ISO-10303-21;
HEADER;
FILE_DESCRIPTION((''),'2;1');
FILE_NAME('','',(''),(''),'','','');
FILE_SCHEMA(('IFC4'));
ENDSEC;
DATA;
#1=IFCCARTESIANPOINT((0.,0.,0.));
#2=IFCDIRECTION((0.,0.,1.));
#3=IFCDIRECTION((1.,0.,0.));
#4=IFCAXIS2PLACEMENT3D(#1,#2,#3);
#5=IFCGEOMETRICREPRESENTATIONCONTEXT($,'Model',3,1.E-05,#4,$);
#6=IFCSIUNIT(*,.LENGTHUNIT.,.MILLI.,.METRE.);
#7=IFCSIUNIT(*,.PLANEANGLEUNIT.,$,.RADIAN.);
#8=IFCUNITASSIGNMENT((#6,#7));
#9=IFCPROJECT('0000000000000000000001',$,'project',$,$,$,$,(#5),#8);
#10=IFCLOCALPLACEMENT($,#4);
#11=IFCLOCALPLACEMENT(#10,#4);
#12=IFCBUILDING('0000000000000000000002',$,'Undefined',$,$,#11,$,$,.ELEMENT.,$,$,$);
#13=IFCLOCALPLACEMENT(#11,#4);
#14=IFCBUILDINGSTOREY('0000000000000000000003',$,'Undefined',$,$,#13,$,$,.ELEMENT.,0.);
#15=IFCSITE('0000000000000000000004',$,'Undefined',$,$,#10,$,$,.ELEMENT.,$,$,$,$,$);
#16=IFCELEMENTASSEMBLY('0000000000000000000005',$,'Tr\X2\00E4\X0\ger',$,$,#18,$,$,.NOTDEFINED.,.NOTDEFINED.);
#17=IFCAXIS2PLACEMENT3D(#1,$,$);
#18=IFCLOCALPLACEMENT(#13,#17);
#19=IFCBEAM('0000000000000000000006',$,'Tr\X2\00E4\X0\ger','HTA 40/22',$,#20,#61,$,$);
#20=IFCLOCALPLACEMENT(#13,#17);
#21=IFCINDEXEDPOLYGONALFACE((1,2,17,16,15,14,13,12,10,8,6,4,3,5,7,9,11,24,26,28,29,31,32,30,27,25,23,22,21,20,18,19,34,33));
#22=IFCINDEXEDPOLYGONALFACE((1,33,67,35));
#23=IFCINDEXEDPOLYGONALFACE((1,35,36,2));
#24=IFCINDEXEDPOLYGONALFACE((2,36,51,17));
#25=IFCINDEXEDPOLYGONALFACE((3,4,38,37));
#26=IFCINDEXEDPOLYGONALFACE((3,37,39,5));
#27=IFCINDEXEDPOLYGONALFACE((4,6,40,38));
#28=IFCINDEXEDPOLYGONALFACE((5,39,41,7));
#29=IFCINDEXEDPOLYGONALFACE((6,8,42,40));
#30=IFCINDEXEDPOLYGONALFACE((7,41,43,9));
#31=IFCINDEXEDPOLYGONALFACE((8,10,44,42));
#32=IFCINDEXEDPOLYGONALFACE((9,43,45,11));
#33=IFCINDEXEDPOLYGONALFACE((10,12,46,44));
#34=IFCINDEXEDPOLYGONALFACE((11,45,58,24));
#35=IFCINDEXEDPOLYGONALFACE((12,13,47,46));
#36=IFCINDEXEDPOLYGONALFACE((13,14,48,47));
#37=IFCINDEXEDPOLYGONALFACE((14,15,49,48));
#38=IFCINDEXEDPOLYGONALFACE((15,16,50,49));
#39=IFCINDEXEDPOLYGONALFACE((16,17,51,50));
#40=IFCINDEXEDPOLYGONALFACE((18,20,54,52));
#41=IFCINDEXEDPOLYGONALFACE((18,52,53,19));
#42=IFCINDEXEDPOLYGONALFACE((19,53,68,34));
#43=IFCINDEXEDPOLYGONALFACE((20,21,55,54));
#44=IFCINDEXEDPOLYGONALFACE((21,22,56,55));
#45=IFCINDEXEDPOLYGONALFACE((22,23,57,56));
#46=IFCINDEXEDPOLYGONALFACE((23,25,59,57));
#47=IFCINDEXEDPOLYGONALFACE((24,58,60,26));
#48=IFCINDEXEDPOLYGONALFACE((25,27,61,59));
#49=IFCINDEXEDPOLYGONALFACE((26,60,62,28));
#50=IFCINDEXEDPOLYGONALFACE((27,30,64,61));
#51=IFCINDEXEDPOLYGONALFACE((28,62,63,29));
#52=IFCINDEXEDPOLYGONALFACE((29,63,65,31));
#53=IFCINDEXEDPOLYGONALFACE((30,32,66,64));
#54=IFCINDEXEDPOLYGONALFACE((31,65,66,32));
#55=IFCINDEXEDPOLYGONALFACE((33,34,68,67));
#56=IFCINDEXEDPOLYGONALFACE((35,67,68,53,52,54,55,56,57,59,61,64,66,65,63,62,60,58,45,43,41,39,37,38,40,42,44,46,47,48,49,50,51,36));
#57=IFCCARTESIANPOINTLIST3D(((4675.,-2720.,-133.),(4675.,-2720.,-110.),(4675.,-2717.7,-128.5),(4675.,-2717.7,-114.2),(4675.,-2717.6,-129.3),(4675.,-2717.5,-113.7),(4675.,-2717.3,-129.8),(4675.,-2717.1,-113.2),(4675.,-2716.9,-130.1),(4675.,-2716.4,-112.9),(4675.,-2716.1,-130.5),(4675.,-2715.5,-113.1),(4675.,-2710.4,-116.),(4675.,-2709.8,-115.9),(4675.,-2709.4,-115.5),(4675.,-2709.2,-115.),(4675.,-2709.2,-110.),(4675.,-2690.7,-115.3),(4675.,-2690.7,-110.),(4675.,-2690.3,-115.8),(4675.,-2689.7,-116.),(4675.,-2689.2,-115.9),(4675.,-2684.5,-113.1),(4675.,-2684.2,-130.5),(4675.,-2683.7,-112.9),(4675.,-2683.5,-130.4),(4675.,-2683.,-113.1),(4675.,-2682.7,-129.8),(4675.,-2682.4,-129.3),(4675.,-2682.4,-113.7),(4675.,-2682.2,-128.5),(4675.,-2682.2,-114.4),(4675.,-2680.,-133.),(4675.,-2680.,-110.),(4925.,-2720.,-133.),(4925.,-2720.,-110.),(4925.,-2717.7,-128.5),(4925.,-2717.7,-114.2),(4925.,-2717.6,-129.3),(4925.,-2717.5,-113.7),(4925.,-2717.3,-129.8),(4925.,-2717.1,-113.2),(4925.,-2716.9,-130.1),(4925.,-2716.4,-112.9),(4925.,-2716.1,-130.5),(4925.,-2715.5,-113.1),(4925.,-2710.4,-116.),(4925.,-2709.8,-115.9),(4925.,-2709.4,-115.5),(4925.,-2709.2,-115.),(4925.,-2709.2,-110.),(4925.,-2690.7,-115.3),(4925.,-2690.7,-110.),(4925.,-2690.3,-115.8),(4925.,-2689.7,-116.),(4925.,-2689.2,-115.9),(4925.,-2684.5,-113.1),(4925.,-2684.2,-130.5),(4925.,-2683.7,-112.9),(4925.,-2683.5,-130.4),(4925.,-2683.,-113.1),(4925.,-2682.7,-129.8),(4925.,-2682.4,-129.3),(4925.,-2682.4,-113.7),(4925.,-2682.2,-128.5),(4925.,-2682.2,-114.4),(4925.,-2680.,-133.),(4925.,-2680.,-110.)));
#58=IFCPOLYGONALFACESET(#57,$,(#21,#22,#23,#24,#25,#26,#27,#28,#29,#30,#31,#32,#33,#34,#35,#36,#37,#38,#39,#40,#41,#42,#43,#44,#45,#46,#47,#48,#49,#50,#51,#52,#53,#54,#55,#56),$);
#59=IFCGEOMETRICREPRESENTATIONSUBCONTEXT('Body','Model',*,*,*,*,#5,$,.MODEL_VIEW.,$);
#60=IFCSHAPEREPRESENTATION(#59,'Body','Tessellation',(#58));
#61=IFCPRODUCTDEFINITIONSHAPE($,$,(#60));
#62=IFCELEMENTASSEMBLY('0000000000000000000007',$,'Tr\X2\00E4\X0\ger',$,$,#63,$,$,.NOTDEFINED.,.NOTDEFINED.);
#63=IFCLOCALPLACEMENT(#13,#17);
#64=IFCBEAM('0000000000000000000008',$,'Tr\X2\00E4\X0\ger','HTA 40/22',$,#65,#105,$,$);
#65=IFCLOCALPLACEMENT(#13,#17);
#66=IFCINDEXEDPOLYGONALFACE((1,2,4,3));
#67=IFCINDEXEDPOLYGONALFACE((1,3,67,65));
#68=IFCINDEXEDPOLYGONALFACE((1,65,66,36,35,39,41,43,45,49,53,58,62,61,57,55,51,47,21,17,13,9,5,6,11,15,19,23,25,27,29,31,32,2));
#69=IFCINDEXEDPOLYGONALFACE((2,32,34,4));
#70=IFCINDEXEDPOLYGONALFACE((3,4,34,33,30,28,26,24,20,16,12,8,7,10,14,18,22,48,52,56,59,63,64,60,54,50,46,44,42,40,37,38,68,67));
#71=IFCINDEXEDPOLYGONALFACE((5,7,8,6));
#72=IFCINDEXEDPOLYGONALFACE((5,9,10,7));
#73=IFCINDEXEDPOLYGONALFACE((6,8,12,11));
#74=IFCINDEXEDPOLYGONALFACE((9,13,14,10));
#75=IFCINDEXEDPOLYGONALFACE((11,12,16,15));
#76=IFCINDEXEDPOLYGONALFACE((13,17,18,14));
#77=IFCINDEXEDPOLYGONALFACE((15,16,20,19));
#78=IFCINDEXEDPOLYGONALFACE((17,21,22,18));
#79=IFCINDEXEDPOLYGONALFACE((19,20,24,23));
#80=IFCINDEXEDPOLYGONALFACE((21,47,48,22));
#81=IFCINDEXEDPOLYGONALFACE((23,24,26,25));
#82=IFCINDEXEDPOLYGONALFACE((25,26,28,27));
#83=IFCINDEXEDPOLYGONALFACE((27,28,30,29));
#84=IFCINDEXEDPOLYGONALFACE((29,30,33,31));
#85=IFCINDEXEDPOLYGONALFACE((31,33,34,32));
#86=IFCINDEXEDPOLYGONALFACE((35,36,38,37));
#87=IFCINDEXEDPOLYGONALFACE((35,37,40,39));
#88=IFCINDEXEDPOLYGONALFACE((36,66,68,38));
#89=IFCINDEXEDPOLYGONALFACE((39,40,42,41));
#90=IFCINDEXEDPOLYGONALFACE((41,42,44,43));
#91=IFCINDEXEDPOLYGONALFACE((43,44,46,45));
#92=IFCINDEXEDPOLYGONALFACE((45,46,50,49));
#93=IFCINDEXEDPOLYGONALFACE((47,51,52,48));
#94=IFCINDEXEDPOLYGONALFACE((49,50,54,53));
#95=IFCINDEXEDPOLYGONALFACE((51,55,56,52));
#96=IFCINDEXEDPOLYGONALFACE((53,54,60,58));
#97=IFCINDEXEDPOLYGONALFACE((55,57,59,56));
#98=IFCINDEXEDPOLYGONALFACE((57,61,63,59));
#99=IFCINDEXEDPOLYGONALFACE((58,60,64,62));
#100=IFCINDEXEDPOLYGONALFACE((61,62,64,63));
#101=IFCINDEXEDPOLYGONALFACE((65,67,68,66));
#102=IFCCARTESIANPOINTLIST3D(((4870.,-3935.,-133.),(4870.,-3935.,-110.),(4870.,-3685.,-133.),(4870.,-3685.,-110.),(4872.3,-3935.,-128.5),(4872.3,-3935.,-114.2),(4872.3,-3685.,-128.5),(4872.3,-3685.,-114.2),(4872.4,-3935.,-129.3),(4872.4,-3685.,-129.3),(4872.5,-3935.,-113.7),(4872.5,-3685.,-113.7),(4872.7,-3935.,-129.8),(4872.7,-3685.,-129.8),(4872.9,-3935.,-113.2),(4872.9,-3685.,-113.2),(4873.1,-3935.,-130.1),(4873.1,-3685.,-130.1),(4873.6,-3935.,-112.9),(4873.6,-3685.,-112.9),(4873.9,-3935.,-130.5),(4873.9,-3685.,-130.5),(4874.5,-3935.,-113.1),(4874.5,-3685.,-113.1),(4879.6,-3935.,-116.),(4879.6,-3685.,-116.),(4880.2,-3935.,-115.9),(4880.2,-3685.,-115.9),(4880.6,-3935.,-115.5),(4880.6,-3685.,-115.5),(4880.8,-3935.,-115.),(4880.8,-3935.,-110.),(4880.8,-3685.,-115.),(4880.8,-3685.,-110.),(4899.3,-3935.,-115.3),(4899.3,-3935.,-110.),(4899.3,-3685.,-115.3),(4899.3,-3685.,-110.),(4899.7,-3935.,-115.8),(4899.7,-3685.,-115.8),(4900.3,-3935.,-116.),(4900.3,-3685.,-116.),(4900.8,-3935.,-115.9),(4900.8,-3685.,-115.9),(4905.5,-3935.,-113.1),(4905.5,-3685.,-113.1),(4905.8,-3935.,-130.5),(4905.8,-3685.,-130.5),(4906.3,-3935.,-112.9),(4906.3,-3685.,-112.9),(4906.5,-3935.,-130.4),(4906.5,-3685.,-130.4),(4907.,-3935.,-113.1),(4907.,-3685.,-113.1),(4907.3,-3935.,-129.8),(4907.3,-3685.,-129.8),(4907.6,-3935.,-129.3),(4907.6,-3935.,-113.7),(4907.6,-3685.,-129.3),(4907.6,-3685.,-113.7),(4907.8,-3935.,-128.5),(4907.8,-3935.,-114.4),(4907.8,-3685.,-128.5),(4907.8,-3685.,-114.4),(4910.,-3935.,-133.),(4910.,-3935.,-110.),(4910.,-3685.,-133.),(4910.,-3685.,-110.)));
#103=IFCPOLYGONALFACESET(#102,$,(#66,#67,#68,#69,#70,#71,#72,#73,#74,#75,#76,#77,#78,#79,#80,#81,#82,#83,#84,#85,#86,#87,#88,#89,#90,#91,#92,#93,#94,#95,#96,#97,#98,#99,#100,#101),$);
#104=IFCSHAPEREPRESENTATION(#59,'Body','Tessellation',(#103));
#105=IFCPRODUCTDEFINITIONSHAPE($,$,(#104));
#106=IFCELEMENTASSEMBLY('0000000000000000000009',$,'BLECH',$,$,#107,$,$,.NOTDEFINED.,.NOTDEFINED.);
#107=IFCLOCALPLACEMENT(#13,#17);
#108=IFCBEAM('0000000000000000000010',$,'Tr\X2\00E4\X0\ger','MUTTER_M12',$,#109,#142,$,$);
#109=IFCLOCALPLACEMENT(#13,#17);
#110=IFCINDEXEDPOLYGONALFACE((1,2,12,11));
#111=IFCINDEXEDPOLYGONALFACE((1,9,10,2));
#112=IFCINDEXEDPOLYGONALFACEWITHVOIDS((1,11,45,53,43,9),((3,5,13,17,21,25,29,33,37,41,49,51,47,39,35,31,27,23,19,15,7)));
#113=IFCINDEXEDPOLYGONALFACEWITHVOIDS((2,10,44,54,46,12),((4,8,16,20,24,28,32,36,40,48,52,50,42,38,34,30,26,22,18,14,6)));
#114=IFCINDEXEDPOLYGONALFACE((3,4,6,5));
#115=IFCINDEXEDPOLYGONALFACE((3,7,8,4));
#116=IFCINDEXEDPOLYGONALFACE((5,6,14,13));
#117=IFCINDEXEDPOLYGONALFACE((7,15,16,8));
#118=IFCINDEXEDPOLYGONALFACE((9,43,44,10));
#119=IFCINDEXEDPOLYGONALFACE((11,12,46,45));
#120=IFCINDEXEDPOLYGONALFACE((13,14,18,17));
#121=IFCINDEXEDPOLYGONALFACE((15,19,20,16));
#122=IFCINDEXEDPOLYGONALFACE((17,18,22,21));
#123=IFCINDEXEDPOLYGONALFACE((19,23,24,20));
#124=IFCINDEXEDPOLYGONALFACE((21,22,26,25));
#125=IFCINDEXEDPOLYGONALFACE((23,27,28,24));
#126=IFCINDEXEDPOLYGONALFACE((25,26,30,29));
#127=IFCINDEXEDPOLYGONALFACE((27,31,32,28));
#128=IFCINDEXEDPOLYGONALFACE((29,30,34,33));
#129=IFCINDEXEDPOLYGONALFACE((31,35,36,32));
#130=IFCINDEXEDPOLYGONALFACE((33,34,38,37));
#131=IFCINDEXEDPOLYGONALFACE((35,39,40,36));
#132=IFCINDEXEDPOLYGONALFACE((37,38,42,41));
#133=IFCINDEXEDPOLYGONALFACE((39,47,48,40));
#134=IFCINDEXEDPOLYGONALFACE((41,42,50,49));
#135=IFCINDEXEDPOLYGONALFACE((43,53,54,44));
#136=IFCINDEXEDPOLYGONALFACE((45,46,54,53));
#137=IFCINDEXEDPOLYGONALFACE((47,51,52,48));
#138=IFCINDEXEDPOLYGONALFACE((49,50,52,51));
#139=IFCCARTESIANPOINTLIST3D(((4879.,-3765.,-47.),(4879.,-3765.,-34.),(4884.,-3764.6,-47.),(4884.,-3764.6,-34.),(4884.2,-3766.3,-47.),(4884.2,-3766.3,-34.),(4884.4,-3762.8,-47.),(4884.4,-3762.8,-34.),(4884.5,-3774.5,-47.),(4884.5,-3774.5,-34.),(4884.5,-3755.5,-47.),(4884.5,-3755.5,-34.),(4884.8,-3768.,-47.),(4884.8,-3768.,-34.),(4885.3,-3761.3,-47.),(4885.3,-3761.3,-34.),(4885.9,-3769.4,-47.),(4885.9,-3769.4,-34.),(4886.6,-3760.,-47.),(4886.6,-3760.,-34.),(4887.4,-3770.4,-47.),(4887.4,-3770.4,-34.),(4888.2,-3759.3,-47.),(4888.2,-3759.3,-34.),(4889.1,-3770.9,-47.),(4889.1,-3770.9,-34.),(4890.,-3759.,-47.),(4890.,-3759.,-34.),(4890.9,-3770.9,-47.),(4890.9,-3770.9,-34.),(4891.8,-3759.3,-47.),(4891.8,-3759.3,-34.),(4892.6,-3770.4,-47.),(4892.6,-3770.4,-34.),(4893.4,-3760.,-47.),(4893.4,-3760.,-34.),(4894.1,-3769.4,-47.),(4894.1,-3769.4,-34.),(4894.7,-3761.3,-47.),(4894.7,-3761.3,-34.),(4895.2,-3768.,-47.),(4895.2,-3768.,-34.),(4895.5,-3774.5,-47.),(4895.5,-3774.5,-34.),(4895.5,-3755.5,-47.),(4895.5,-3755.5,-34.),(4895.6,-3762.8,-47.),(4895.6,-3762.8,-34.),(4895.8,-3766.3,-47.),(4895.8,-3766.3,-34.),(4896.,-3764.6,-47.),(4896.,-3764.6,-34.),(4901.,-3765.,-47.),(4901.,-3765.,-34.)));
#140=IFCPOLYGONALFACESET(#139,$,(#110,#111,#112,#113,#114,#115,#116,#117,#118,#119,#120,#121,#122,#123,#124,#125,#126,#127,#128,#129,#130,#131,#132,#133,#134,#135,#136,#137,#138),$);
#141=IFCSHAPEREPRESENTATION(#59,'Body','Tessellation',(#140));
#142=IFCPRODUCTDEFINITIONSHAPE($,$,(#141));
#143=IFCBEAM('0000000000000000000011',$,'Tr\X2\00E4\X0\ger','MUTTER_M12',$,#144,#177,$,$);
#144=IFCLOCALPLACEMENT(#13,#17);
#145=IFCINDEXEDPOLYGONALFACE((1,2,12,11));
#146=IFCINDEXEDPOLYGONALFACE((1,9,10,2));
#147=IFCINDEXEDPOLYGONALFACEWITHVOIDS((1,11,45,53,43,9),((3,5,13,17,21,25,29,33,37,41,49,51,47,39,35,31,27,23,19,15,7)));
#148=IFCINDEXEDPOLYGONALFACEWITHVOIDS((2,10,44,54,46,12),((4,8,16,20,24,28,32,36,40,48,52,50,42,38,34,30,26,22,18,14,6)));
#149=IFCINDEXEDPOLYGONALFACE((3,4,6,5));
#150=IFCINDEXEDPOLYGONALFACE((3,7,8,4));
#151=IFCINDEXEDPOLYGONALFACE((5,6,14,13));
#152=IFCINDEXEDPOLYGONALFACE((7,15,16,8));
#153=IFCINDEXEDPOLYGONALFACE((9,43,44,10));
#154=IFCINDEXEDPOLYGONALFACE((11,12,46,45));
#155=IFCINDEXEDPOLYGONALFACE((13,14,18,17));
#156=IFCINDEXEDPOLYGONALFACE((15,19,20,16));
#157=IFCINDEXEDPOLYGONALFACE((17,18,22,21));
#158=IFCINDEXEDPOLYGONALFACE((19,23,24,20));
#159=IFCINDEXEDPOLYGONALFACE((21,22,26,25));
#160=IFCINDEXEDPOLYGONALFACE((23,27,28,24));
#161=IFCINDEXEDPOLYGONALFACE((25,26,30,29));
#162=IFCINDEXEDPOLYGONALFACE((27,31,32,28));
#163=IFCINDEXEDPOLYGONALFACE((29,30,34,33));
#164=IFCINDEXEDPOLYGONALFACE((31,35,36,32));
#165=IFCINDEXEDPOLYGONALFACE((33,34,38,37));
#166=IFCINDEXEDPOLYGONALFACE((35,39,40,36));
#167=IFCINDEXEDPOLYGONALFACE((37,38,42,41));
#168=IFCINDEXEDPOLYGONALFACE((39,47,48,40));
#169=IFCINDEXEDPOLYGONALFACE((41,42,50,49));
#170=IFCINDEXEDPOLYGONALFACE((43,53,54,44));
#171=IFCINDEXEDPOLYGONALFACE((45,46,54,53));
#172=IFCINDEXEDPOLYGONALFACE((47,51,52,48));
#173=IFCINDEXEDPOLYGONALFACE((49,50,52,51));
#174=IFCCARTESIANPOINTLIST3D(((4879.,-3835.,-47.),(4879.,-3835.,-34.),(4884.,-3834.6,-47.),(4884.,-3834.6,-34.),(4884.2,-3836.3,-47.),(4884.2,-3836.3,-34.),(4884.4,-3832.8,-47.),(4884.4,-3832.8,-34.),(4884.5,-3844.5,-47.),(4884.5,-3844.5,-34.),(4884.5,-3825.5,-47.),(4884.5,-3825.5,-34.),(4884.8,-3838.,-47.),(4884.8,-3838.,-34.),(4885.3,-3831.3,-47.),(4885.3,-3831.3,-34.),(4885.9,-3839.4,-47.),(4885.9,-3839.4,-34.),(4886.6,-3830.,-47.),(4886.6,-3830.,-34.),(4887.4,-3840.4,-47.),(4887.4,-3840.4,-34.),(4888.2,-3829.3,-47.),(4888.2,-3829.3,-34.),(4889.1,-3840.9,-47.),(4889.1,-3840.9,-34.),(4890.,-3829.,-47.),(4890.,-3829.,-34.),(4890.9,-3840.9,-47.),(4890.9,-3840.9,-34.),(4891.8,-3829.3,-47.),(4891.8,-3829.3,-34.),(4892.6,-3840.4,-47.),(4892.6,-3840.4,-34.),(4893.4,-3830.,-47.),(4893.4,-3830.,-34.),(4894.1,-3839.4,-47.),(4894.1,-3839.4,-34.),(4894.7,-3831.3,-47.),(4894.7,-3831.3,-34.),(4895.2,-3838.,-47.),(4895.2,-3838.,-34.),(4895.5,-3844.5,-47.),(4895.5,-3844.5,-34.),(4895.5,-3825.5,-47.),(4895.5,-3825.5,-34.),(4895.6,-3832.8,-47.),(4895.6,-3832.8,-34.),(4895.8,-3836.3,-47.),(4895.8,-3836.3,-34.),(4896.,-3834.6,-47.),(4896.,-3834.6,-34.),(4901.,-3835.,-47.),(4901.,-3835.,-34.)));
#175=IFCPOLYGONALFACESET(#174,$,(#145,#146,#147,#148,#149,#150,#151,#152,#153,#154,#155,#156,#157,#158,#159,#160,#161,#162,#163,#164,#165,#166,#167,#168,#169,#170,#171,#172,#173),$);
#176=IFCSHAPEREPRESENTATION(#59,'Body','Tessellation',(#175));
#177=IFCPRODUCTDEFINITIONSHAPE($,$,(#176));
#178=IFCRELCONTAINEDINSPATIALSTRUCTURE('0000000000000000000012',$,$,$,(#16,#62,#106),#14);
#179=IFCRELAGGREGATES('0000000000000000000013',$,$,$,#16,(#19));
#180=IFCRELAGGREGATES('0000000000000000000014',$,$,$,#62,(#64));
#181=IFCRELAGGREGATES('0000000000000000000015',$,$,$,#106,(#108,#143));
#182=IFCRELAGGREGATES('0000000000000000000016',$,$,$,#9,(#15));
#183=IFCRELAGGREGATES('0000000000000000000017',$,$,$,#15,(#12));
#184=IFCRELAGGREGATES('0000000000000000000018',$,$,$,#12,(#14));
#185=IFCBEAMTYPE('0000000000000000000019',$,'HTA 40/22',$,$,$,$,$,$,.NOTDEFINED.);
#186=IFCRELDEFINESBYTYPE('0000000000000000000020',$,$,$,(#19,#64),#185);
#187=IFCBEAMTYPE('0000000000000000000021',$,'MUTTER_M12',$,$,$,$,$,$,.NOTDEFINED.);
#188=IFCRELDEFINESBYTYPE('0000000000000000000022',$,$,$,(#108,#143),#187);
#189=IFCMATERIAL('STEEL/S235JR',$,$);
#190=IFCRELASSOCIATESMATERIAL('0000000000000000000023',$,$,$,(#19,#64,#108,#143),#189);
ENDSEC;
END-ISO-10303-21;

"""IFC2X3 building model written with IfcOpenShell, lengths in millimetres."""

from ifc_helpers import new_model, si_unit, frame, origin_with_axes, origin_2d_with_axis, place, context, subcontext, project, spatial, polyline, circle, outline, extrude, boolean, material, type_object, element, aggregate, save


model = new_model("IFC2X3")

# Units and contexts
model_context = context("Model", 3, precision=1e-05, world=origin_with_axes())
body_context = subcontext(model_context, "Body", "Model", "MODEL_VIEW")
ifc_project = project(units=[si_unit("LENGTHUNIT", "METRE", prefix="MILLI"), si_unit("PLANEANGLEUNIT", "RADIAN")], contexts=[model_context])

# Site, building, storey
site_placement = place(None, origin_with_axes())
site = spatial("IfcSite", under=ifc_project, at=site_placement, Name="Undefined", CompositionType="ELEMENT")
building_placement = place(site_placement, origin_with_axes())
building = spatial("IfcBuilding", under=site, at=building_placement, Name="Undefined", CompositionType="ELEMENT")
storey_placement = place(building_placement, origin_with_axes())
storey = spatial("IfcBuildingStorey", under=building, at=storey_placement, Name="Undefined", CompositionType="ELEMENT", Elevation=0.0)

# Element assemblies, beams
assembly_1_placement = place(storey_placement, origin_with_axes())
assembly_1 = element("IfcElementAssembly", 1, at=assembly_1_placement, inside=storey, Name="Träger", AssemblyPlace="NOTDEFINED", PredefinedType="NOTDEFINED")
ifc_material_1 = material(Name="STEEL/S235JR")
beam_type_1 = type_object("IfcBeamType", Name="HTA 40/22", PredefinedType="NOTDEFINED")
beam_1_placement = place(assembly_1_placement, frame((4925.0, -2700.0, -121.5), z_axis=(0.0, 0.0, -1.0), x_axis=(-1.0, 0.0, 0.0)))
beam_1 = element("IfcBeam", 2, at=beam_1_placement, type_object=beam_type_1, material=ifc_material_1, Name="Träger", Description="HTA 40/22", context=body_context, shape_type="SweptSolid", body=[
    extrude(outline(polyline([(-9.3, -6.2), (-9.2, -11.5), (-20.0, -11.5), (-20.0, 11.5), (20.0, 11.5), (20.0, -11.5), (9.2, -11.5), (9.2, -6.5), (9.4, -6.0), (9.8, -5.6), (10.4, -5.5), (15.5, -8.4), (16.4, -8.6), (17.1, -8.3), (17.5, -7.8), (17.7, -7.3), (17.8, 7.0), (17.6, 7.8), (17.3, 8.3), (16.9, 8.6), (16.1, 9.0), (-15.8, 9.0), (-16.5, 8.9), (-17.3, 8.3), (-17.6, 7.8), (-17.8, 7.0), (-17.8, -7.1), (-17.5, -7.8), (-17.0, -8.4), (-16.2, -8.6), (-15.5, -8.4), (-10.8, -5.6), (-10.2, -5.5), (-9.7, -5.7), (-9.3, -6.2)])), frame((250.0, 0.0, 0.0), z_axis=(-1.0, 0.0, 0.0), x_axis=(0.0, -1.0, 0.0)), (0.0, 0.0, 1.0), 250.0),
])
aggregate(assembly_1, [beam_1])
assembly_2_placement = place(storey_placement, origin_with_axes())
assembly_2 = element("IfcElementAssembly", 3, at=assembly_2_placement, inside=storey, Name="Träger", AssemblyPlace="NOTDEFINED", PredefinedType="NOTDEFINED")
beam_2_placement = place(assembly_2_placement, frame((4890.0, -3935.0, -121.5), z_axis=(0.0, 0.0, -1.0), x_axis=(0.0, 1.0, 0.0)))
beam_2 = element("IfcBeam", 4, at=beam_2_placement, type_object=beam_type_1, material=ifc_material_1, Name="Träger", Description="HTA 40/22", context=body_context, shape_type="SweptSolid", body=[
    extrude(outline(polyline([(-9.3, -6.2), (-9.2, -11.5), (-20.0, -11.5), (-20.0, 11.5), (20.0, 11.5), (20.0, -11.5), (9.2, -11.5), (9.2, -6.5), (9.4, -6.0), (9.8, -5.6), (10.4, -5.5), (15.5, -8.4), (16.4, -8.6), (17.1, -8.3), (17.5, -7.8), (17.7, -7.3), (17.8, 7.0), (17.6, 7.8), (17.3, 8.3), (16.9, 8.6), (16.1, 9.0), (-15.8, 9.0), (-16.5, 8.9), (-17.3, 8.3), (-17.6, 7.8), (-17.8, 7.0), (-17.8, -7.1), (-17.5, -7.8), (-17.0, -8.4), (-16.2, -8.6), (-15.5, -8.4), (-10.8, -5.6), (-10.2, -5.5), (-9.7, -5.7), (-9.3, -6.2)])), frame((250.0, 0.0, 0.0), z_axis=(-1.0, 0.0, 0.0), x_axis=(0.0, -1.0, 0.0)), (0.0, 0.0, 1.0), 250.0),
])
aggregate(assembly_2, [beam_2])

# Element assembly, beams
assembly_3_placement = place(storey_placement, origin_with_axes())
assembly_3 = element("IfcElementAssembly", 5, at=assembly_3_placement, inside=storey, Name="BLECH", AssemblyPlace="NOTDEFINED", PredefinedType="NOTDEFINED")
beam_type_2 = type_object("IfcBeamType", Name="MUTTER_M12", PredefinedType="NOTDEFINED")
beam_3_placement = place(assembly_3_placement, frame((4890.0, -3765.0, -34.0), z_axis=(-1.0, 0.0, 0.0), x_axis=(0.0, 0.0, -1.0)))
beam_3 = element("IfcBeam", 6, at=beam_3_placement, type_object=beam_type_2, material=ifc_material_1, Name="Träger", Description="MUTTER_M12", context=body_context, shape_type="CSG", body=[
    boolean("DIFFERENCE", extrude(outline(polyline([(9.5, 5.5), (9.5, -5.5), (0.0, -11.0), (-9.5, -5.5), (-9.5, 5.5), (0.0, 11.0), (9.5, 5.5)])), frame((13.0, 0.0, 0.0), z_axis=(-1.0, 0.0, 0.0), x_axis=(0.0, -1.0, 0.0)), (0.0, 0.0, 1.0), 13.0), extrude(circle(Radius=6.0, at=origin_2d_with_axis()), frame((36.0, 0.0, 0.0), z_axis=(-1.0, 0.0, 0.0), x_axis=(0.0, -1.0, 0.0)), (0.0, 0.0, 1.0), 60.0)),
])
beam_4_placement = place(assembly_3_placement, frame((4890.0, -3835.0, -34.0), z_axis=(-1.0, 0.0, 0.0), x_axis=(0.0, 0.0, -1.0)))
beam_4 = element("IfcBeam", 7, at=beam_4_placement, type_object=beam_type_2, material=ifc_material_1, Name="Träger", Description="MUTTER_M12", context=body_context, shape_type="CSG", body=[
    boolean("DIFFERENCE", extrude(outline(polyline([(9.5, 5.5), (9.5, -5.5), (0.0, -11.0), (-9.5, -5.5), (-9.5, 5.5), (0.0, 11.0), (9.5, 5.5)])), frame((13.0, 0.0, 0.0), z_axis=(-1.0, 0.0, 0.0), x_axis=(0.0, -1.0, 0.0)), (0.0, 0.0, 1.0), 13.0), extrude(circle(Radius=6.0, at=origin_2d_with_axis()), frame((36.0, 0.0, 0.0), z_axis=(-1.0, 0.0, 0.0), x_axis=(0.0, -1.0, 0.0)), (0.0, 0.0, 1.0), 60.0)),
])
aggregate(assembly_3, [beam_3, beam_4])

save(model, "model.ifc")
